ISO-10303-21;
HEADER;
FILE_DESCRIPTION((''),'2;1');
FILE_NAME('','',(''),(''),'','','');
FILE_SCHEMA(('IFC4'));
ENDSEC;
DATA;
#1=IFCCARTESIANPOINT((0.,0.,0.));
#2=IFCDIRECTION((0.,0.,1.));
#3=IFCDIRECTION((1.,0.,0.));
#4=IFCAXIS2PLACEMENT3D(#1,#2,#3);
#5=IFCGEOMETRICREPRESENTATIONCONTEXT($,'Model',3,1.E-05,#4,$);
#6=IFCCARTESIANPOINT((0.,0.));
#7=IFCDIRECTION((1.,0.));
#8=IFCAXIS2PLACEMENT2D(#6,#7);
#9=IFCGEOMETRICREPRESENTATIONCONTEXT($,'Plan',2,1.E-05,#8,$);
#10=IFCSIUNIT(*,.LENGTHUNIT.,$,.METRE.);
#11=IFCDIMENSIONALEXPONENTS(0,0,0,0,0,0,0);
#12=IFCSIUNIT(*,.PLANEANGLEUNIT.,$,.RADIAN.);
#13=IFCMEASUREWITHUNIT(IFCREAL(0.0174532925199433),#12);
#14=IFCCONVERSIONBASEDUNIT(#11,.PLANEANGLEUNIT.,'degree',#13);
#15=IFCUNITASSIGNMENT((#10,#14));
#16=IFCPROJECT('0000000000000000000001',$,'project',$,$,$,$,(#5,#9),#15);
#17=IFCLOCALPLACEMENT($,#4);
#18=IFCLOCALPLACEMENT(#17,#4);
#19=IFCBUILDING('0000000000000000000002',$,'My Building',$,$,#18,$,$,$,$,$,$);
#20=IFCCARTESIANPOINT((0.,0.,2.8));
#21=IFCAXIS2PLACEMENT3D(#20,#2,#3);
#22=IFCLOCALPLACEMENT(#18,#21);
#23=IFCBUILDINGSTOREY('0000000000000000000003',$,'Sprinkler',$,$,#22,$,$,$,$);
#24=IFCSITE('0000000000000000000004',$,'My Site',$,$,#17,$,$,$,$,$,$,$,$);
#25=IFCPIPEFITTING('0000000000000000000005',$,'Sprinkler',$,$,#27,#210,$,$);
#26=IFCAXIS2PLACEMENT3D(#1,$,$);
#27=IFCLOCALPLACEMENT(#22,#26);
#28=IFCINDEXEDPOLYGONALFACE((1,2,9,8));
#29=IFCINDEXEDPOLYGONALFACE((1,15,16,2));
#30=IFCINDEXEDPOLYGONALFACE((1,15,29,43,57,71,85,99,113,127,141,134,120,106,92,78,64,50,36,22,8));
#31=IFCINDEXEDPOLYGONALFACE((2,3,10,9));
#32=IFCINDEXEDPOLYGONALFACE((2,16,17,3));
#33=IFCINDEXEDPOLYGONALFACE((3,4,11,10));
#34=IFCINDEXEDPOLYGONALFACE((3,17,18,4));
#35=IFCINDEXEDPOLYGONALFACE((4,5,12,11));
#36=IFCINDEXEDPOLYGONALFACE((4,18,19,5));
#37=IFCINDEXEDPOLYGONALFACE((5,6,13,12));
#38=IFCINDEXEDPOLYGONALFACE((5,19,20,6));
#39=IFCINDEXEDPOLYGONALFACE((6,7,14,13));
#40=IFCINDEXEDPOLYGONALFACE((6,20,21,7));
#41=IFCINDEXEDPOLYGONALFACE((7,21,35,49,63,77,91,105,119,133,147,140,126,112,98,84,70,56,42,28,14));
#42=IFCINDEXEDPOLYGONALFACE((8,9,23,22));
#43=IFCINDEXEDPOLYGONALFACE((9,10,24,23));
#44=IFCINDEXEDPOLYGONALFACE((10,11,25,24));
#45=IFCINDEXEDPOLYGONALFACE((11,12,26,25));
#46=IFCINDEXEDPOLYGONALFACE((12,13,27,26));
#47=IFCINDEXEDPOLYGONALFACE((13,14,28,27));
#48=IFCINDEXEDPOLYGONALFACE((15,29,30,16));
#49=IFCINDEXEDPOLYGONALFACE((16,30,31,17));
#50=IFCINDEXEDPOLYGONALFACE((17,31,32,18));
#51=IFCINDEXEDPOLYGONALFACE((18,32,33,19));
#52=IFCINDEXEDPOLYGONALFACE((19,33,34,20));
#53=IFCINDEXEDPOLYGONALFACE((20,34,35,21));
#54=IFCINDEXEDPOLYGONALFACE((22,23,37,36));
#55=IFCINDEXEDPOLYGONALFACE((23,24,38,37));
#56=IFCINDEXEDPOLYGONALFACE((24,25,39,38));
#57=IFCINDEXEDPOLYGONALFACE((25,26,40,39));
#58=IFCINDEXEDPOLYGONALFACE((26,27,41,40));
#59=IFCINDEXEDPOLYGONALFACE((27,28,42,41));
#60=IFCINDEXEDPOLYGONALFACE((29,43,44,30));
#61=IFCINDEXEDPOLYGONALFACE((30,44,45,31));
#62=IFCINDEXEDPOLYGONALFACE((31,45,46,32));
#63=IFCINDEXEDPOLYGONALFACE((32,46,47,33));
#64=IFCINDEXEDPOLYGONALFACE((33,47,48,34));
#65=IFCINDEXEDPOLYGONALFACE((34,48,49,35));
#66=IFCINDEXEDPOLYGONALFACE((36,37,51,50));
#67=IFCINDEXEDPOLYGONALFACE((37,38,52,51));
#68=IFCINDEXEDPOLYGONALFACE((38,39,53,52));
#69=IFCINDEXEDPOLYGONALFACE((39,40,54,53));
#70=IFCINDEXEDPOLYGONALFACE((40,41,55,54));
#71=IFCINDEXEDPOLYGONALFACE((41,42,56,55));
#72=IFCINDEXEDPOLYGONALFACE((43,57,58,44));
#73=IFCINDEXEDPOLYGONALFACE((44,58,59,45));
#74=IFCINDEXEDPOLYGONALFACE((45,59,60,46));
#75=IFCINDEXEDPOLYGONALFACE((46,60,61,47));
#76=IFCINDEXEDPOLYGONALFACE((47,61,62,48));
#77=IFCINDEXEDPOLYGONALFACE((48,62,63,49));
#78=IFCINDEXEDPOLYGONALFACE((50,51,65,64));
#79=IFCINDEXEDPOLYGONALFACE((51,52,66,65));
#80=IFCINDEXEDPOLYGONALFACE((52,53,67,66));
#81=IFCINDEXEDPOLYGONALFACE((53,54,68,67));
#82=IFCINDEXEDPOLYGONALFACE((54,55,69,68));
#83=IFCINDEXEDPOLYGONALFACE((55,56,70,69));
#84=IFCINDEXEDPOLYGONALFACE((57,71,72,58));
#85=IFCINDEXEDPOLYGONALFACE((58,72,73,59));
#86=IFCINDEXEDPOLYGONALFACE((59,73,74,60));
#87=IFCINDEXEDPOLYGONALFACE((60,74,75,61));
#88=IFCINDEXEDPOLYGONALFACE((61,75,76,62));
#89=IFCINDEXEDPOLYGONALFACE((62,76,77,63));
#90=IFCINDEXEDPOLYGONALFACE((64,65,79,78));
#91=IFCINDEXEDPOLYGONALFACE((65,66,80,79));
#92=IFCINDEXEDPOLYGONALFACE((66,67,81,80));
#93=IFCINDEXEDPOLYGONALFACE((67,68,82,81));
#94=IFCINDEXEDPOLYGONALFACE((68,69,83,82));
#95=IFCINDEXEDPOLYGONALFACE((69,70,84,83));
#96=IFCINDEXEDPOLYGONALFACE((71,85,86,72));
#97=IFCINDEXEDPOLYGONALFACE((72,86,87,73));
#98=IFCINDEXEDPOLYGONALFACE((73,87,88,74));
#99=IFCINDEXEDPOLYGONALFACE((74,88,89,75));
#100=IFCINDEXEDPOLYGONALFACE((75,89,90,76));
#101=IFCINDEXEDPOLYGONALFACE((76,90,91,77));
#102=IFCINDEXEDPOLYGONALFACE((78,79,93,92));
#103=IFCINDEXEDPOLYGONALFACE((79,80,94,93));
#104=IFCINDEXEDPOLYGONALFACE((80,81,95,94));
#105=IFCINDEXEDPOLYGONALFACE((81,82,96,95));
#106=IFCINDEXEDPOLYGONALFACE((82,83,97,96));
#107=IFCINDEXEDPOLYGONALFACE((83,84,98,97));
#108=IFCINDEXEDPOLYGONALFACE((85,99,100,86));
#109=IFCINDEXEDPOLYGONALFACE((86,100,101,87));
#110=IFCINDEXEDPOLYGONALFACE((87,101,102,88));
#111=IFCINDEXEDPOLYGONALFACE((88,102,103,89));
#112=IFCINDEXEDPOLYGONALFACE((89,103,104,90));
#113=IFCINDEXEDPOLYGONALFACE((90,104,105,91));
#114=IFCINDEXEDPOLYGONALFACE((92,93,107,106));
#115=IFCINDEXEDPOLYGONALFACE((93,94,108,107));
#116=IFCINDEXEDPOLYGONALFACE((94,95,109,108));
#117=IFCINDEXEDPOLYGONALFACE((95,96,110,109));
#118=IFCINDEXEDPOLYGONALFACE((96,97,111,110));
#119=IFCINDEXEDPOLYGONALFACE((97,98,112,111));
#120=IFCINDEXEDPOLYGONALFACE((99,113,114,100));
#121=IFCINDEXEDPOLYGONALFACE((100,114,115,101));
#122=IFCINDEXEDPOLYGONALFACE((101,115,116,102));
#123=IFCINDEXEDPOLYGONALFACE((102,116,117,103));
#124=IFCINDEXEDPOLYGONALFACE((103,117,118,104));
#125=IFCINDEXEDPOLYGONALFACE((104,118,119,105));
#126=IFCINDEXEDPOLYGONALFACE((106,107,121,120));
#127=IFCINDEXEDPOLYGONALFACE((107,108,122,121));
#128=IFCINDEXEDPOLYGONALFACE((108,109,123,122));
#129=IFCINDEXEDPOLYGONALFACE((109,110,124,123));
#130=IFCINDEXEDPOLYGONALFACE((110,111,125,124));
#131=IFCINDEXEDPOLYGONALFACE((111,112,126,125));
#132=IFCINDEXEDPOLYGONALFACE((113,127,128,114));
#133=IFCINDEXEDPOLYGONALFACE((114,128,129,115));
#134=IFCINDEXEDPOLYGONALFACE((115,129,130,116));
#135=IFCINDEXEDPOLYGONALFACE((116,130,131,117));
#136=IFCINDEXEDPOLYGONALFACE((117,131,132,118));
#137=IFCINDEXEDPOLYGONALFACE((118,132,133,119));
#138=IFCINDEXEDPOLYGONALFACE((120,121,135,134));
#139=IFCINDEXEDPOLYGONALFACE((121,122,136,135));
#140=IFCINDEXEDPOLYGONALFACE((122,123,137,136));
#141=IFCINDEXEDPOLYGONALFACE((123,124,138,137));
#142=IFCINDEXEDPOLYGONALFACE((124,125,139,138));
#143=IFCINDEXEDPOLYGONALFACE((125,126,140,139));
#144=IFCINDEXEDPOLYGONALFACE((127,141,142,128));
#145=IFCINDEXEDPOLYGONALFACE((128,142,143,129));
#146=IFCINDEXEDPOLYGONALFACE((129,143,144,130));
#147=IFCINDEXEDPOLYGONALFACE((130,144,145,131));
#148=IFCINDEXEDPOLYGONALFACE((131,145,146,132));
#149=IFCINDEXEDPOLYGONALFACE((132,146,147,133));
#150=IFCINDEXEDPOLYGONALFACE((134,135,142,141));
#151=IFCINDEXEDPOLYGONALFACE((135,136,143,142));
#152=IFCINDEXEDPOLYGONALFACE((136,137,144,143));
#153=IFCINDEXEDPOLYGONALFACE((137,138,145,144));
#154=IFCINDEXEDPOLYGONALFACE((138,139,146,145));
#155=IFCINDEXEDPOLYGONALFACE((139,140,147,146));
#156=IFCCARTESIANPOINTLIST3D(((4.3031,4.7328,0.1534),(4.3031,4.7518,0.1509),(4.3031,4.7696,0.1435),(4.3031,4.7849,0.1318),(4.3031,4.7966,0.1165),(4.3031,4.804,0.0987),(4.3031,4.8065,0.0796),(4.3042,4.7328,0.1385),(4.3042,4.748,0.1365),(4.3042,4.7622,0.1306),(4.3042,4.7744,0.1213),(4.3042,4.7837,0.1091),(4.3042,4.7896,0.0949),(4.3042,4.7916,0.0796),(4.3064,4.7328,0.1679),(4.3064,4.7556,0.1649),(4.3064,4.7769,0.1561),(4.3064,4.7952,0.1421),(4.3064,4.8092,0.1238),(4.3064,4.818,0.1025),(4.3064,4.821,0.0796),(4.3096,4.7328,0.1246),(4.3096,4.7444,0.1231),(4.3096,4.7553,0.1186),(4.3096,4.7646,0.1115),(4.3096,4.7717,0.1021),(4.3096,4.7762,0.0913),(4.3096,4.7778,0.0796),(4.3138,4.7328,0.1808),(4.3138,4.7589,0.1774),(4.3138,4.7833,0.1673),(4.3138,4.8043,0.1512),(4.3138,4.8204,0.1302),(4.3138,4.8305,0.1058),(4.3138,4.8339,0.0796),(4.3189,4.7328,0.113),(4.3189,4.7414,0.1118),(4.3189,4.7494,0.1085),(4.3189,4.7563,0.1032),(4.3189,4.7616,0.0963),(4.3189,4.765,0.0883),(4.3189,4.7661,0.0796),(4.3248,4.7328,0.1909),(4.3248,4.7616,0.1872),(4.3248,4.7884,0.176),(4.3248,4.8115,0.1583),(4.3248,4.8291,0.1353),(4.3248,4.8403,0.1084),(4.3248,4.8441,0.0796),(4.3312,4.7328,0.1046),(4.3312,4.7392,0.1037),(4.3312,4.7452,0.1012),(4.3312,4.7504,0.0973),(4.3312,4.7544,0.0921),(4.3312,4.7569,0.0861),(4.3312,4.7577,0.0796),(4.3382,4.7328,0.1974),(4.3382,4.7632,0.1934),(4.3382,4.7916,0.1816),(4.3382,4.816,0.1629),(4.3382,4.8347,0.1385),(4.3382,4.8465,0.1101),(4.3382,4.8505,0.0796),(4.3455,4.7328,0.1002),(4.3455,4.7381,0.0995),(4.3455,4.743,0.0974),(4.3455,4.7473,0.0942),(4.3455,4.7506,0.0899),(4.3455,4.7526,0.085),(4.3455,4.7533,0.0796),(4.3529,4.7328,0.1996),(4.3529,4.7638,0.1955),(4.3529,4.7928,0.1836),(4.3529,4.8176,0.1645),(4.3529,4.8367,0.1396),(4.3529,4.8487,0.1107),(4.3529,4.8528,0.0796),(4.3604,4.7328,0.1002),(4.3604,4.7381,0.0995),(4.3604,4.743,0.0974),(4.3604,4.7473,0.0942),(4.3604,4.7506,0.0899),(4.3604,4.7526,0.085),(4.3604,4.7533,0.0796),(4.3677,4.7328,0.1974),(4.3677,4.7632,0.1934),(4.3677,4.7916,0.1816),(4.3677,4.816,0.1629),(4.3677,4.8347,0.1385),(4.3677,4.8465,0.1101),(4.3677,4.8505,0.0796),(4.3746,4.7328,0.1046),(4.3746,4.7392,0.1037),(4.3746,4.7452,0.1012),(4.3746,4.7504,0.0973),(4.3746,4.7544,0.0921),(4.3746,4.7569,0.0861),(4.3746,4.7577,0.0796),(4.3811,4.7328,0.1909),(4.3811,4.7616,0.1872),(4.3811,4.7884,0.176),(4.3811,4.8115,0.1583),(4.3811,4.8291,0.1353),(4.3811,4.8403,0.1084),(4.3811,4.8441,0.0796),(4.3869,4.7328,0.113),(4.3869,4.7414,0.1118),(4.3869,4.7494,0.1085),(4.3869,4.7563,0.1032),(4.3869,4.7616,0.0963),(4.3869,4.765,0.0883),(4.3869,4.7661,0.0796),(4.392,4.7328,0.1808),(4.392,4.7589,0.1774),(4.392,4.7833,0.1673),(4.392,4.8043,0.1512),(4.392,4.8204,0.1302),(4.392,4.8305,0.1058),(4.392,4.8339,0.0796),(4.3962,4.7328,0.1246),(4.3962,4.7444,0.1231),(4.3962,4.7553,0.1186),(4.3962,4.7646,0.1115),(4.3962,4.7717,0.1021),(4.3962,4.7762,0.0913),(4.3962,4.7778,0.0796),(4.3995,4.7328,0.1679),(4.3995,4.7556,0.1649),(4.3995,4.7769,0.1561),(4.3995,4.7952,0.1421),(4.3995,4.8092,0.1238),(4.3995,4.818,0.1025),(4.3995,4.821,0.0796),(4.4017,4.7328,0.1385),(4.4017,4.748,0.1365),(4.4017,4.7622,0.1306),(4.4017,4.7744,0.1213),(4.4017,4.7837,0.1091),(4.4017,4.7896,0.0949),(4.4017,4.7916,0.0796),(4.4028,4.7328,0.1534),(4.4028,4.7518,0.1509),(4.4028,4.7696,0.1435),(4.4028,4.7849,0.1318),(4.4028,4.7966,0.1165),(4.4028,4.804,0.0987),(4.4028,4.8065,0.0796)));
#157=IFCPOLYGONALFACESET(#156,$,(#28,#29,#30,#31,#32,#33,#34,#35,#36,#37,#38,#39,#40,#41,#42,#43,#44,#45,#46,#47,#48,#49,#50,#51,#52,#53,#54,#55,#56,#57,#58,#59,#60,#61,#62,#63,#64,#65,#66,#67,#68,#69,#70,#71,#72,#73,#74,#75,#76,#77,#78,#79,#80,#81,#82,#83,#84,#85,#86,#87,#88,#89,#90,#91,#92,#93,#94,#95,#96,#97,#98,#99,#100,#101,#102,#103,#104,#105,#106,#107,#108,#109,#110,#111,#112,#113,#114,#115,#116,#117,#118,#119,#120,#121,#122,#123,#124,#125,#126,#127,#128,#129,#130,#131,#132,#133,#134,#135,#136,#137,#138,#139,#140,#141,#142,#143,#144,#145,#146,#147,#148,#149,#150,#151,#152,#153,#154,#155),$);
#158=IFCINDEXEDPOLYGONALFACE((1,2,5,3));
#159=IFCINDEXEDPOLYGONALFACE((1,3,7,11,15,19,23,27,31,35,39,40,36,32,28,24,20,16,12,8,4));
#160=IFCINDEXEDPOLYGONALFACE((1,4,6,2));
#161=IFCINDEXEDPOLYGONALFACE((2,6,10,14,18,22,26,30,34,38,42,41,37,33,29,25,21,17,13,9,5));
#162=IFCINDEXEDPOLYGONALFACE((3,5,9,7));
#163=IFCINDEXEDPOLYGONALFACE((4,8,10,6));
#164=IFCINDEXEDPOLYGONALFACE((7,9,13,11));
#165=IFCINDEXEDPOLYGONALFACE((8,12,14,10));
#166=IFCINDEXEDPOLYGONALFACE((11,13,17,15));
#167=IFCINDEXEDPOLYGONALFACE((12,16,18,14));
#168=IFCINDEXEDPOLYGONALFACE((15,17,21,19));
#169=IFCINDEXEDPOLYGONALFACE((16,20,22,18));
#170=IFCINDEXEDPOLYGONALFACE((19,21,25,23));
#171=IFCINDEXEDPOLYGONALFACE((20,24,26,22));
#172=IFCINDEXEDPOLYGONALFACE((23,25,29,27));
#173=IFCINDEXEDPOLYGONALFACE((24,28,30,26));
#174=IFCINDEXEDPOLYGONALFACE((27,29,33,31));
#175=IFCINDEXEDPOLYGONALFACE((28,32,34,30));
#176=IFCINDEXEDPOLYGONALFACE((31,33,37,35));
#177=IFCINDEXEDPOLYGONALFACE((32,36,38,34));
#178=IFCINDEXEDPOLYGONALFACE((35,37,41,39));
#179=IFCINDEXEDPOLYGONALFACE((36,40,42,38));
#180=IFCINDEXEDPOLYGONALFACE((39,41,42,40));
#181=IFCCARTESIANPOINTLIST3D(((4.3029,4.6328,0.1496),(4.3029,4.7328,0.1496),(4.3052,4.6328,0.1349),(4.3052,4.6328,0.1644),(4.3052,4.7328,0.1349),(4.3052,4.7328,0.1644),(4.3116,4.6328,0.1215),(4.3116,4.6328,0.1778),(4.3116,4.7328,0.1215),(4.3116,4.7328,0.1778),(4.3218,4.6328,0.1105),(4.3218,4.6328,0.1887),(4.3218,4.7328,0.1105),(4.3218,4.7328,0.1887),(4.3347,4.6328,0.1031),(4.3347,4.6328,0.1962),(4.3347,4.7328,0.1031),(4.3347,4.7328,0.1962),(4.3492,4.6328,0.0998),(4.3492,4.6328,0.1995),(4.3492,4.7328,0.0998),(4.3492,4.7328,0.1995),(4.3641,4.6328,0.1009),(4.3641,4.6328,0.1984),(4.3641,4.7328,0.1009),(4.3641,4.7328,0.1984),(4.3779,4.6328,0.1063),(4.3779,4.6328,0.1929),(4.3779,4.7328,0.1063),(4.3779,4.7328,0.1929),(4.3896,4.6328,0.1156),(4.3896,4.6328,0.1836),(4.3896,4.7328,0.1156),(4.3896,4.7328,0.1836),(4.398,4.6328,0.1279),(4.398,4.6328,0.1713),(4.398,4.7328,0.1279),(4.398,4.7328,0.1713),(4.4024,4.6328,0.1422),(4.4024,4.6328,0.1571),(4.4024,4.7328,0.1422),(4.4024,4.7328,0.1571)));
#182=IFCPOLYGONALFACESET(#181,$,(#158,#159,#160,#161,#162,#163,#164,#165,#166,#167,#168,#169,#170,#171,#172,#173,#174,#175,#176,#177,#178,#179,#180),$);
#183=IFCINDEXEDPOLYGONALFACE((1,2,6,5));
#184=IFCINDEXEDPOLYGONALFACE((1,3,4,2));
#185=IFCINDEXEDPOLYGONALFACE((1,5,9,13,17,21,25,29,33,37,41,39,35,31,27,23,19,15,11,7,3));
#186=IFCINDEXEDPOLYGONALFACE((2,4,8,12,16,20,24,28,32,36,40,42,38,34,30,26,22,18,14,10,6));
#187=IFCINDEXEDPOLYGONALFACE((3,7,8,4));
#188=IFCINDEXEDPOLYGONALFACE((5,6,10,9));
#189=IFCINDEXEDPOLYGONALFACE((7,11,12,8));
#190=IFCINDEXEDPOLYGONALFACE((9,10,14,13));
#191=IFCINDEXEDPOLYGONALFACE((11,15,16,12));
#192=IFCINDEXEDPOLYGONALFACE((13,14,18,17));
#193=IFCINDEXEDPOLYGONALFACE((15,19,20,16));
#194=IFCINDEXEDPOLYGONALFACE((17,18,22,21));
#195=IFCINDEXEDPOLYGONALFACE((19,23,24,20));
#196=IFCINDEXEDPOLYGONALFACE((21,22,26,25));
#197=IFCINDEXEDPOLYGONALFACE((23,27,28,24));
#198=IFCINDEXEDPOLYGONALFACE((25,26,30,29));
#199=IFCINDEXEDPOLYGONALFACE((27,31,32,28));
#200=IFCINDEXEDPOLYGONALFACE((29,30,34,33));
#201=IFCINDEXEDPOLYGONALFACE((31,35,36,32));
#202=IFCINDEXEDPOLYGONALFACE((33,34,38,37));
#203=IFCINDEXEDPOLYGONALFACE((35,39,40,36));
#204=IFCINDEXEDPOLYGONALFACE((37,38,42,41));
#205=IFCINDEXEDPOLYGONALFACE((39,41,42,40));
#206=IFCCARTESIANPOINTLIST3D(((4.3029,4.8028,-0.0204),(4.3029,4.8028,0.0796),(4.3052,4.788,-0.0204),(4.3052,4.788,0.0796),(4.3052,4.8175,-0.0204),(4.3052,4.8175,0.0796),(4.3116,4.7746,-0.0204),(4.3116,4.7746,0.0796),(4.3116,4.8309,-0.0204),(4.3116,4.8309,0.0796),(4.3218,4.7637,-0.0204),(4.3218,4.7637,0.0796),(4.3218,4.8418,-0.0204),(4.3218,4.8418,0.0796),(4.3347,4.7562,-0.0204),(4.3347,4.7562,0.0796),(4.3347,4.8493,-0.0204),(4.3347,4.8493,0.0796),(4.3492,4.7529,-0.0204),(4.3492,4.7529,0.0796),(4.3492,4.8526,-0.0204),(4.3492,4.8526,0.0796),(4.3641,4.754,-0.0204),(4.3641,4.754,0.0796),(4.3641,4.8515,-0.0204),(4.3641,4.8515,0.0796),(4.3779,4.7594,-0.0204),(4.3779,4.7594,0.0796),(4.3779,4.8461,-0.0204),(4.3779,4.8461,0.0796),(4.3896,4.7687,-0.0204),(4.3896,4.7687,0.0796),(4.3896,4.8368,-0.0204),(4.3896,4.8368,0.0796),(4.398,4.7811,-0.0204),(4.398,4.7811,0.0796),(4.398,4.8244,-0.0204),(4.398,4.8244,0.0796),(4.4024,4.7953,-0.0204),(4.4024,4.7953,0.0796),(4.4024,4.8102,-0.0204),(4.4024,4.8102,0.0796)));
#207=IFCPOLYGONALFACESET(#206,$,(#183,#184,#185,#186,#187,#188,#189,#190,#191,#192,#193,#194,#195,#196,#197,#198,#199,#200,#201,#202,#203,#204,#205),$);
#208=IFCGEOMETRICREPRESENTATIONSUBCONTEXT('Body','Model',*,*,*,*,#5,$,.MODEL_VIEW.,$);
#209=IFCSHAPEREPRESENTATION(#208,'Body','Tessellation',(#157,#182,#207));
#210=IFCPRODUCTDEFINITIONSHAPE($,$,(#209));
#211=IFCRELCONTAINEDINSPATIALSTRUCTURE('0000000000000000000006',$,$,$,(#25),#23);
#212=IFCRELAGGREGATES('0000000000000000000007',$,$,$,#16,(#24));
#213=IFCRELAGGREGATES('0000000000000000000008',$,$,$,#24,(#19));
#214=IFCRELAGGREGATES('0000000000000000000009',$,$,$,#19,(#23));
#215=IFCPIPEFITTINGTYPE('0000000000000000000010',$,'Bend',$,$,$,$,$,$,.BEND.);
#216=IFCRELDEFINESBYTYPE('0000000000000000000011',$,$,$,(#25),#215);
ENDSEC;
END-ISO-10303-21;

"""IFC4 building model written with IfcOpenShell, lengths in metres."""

from ifc_helpers import new_model, entity, si_unit, converted_unit, frame, origin_with_axes, origin_2d_with_axis, place, context, subcontext, project, spatial, circle, extrude, source, transform, mapped, type_object, type_shapes, element, save


model = new_model("IFC4")

# Units and contexts
model_context = context("Model", 3, precision=1e-05, world=origin_with_axes())
plan_context = context("Plan", 2, precision=1e-05, world=origin_2d_with_axis())
body_context = subcontext(model_context, "Body", "Model", "MODEL_VIEW")
ifc_project = project(units=[si_unit("LENGTHUNIT", "METRE"), converted_unit("PLANEANGLEUNIT", "degree", entity("IfcReal", 0.0174532925199433), si_unit("PLANEANGLEUNIT", "RADIAN"), dimensions=[0, 0, 0, 0, 0, 0, 0])], contexts=[model_context, plan_context])

# Site, building, storey
site_placement = place(None, origin_with_axes())
site = spatial("IfcSite", under=ifc_project, at=site_placement, Name="My Site")
building_placement = place(site_placement, origin_with_axes())
building = spatial("IfcBuilding", under=site, at=building_placement, Name="My Building")
storey_placement = place(building_placement, frame((0.0, 0.0, 2.8), z_axis=(0.0, 0.0, 1.0), x_axis=(1.0, 0.0, 0.0)))
storey = spatial("IfcBuildingStorey", under=building, at=storey_placement, Name="Sprinkler")

# Pipe fitting
pipe_fitting_type_1 = type_object("IfcPipeFittingType", Name="Bend", PredefinedType="BEND")
shared_shape_1 = source(origin_with_axes(), body_context, "Body", "SolidModel", [
    entity("IfcSweptDiskSolid", entity("IfcIndexedPolyCurve", entity("IfcCartesianPointList3D", [[0.0, 0.0, 0.1], [0.0, -0.0205, 0.1495], [0.0, -0.07, 0.17]]), [entity("IfcArcIndex", [1, 2, 3])]), 0.05),
    extrude(circle(Radius=0.05), origin_with_axes(), (0.0, 0.0, 1.0), 0.1),
    extrude(circle(Radius=0.05), frame((0.0, -0.07, 0.17), z_axis=(0.0, -1.0, 0.0), x_axis=(1.0, 0.0, 0.0)), (0.0, 0.0, 1.0), 0.1),
])
type_shapes(pipe_fitting_type_1, [shared_shape_1])
for number, where, z_axis, x_axis, name in (
    (1, (4.3529, 4.6328, 0.1496), (-0.000001, 1.0, 0.0), (-1.0, -0.000001, 0.0), "Sprinkler"),
):
    element("IfcPipeFitting", number, at=place(storey_placement, frame(where, z_axis=z_axis, x_axis=x_axis)), inside=storey, type_object=pipe_fitting_type_1, Name=name, context=body_context, shape_type="MappedRepresentation", body=[
        mapped(shared_shape_1, transform((0.0, 0.0, 0.0), x_axis=(1.0, 0.0, 0.0), y_axis=(0.0, 1.0, 0.0), z_axis=(0.0, 0.0, 1.0), scale=1.0)),
    ])

save(model, "model.ifc")
